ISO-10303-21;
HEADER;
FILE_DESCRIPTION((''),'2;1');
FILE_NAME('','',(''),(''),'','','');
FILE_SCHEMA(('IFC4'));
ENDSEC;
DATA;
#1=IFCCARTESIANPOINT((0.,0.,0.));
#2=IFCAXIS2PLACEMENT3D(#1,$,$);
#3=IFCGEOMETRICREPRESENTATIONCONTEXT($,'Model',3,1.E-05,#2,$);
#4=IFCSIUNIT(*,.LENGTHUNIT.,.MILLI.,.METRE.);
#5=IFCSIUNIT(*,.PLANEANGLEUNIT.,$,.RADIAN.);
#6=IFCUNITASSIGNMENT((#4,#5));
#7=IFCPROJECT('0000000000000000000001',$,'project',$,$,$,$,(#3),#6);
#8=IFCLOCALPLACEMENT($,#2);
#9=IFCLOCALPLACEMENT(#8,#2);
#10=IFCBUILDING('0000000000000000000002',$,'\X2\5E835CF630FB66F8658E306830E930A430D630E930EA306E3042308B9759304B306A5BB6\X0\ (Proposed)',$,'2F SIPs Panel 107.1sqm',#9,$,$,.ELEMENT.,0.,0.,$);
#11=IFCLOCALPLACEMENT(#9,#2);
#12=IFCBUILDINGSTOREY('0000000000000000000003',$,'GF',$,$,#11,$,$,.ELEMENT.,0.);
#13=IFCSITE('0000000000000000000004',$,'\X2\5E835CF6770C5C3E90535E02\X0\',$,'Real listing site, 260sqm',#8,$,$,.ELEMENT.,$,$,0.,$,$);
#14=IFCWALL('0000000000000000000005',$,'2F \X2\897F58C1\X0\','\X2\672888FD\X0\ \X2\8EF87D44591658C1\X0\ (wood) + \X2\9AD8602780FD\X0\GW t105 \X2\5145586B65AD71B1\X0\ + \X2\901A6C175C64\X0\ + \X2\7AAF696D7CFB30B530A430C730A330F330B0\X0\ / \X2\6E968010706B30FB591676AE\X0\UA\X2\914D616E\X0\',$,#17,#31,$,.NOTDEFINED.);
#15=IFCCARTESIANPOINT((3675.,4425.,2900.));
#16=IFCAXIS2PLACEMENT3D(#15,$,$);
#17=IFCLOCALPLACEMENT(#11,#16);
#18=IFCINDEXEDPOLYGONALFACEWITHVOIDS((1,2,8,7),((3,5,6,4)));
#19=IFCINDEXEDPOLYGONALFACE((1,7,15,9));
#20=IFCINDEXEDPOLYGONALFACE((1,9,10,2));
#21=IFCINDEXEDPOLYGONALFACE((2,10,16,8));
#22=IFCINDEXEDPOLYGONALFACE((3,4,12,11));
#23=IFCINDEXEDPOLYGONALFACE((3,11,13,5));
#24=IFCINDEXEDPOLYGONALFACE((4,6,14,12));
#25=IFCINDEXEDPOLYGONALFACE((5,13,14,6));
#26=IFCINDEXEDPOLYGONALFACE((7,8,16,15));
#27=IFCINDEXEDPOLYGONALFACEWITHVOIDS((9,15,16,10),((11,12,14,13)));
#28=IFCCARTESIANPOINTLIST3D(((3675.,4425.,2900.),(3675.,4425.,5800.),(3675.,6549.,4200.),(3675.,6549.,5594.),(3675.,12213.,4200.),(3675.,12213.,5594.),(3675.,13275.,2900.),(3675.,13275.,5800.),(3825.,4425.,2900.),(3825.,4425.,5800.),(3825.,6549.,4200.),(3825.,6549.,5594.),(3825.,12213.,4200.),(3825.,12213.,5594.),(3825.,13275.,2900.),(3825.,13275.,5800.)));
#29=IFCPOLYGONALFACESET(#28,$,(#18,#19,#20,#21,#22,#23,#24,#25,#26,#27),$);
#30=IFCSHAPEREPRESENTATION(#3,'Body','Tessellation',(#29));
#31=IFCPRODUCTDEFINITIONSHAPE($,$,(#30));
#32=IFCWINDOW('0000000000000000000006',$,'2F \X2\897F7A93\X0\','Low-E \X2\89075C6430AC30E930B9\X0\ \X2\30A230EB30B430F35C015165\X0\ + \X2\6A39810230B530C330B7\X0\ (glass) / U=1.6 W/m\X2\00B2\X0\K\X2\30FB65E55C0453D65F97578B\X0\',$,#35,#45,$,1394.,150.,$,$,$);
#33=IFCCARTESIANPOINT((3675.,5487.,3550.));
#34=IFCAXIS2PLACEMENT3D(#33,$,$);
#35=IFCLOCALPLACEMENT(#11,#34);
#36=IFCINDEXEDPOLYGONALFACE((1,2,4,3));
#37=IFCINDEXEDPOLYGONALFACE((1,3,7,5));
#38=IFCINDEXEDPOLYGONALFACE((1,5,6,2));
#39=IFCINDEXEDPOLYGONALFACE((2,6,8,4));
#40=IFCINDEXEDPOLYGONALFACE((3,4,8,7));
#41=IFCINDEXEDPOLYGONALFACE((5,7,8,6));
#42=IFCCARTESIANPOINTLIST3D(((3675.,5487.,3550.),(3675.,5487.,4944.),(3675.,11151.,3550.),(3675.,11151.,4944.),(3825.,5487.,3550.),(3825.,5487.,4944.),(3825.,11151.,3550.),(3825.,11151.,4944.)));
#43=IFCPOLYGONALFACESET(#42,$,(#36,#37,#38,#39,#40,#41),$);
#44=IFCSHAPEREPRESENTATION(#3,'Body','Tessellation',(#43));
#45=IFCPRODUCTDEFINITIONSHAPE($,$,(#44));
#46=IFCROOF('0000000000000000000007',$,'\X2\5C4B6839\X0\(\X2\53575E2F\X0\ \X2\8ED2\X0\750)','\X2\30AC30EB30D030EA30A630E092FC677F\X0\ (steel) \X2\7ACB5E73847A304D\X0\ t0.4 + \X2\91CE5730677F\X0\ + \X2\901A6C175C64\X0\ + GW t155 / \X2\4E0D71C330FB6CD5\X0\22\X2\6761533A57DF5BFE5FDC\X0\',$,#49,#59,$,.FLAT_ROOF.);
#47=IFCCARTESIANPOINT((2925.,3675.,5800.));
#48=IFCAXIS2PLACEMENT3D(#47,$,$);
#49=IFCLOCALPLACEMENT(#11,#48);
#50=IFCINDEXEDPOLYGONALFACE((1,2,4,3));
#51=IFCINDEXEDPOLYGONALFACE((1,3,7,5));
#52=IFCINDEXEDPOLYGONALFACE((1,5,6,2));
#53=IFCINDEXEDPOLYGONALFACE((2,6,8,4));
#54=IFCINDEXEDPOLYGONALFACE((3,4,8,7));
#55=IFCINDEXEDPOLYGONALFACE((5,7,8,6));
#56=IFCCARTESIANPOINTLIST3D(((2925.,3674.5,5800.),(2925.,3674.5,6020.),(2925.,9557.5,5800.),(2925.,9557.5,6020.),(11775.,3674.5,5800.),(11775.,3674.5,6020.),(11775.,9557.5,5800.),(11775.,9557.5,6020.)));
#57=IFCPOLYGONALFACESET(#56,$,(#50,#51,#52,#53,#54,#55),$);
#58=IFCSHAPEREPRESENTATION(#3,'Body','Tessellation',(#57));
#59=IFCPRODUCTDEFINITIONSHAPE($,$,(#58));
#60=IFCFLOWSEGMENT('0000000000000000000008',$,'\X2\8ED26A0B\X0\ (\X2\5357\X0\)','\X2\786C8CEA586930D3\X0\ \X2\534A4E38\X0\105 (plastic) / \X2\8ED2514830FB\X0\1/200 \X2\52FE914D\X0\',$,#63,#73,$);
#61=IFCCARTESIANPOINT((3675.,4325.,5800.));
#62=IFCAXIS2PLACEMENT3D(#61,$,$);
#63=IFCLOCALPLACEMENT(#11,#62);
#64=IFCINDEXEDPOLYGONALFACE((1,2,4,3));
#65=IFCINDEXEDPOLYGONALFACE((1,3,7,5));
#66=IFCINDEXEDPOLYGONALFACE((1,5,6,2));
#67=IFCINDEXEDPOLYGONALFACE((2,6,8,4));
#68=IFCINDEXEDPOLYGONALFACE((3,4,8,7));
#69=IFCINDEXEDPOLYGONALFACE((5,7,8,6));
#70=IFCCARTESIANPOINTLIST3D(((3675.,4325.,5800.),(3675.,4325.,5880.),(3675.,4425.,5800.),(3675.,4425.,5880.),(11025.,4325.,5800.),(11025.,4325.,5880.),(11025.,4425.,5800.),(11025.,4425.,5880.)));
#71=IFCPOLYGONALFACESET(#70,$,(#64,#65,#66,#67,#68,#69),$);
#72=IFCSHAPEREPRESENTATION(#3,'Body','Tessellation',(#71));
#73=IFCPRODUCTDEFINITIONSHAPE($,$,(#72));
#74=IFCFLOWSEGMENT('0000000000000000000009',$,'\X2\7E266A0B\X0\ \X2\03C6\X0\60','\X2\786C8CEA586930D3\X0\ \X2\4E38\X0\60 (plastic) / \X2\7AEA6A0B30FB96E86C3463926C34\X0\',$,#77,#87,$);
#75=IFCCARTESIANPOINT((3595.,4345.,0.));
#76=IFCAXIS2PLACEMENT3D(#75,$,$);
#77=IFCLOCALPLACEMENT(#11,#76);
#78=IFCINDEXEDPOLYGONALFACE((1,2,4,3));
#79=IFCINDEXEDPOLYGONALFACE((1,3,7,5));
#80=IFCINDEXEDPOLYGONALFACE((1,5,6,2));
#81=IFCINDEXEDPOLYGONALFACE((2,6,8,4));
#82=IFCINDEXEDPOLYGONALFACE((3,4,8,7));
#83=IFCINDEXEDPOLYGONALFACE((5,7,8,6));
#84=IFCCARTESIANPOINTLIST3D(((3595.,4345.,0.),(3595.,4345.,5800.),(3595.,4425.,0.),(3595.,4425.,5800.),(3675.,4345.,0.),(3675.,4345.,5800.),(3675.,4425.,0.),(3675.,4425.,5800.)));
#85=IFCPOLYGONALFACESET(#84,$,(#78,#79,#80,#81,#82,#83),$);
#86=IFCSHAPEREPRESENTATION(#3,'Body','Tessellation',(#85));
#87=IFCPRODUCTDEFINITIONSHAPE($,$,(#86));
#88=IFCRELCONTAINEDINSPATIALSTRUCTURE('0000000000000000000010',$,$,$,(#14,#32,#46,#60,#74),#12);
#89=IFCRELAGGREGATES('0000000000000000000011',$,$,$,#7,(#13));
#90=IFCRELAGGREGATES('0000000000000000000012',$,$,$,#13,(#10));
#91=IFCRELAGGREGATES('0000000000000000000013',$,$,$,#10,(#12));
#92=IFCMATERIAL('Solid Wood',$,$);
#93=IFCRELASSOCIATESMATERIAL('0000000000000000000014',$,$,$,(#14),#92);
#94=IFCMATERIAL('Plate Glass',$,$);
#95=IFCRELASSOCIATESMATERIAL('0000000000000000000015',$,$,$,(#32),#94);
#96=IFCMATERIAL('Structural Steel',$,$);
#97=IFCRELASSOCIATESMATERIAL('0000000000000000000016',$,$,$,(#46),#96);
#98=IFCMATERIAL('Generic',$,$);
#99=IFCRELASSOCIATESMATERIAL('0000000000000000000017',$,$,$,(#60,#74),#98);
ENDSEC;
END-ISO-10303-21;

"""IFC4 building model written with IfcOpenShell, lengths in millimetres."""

from ifc_helpers import new_model, si_unit, frame, frame_2d, origin, place, context, project, spatial, rectangle, extrude, material, element, fill, save


model = new_model("IFC4")

# Units and contexts
model_context = context("Model", 3, precision=1e-05, world=origin())
ifc_project = project(units=[si_unit("LENGTHUNIT", "METRE", prefix="MILLI"), si_unit("PLANEANGLEUNIT", "RADIAN")], contexts=[model_context])

# Site, building, storey
site_placement = place(None, origin())
site = spatial("IfcSite", under=ifc_project, at=site_placement, Name="広島県尾道市", ObjectType="Real listing site, 260sqm", CompositionType="ELEMENT", RefElevation=0.0)
building_placement = place(site_placement, origin())
building = spatial("IfcBuilding", under=site, at=building_placement, Name="広島・書斎とライブラリのある静かな家 (Proposed)", ObjectType="2F SIPs Panel 107.1sqm", CompositionType="ELEMENT", ElevationOfRefHeight=0.0, ElevationOfTerrain=0.0)
storey_placement = place(building_placement, origin())
storey = spatial("IfcBuildingStorey", under=building, at=storey_placement, Name="GF", CompositionType="ELEMENT", Elevation=0.0)

# Shared definitions
ifc_material_1 = material(Name="Solid Wood")

# Shared definitions
ifc_material_2 = material(Name="Plate Glass")

# Wall, opening, window
wall_1_placement = place(storey_placement, frame((3675.0, 4425.0, 2900.0)))
wall_1 = element("IfcWall", 1, at=wall_1_placement, inside=storey, material=ifc_material_1, Name="2F 西壁", Description="木製 軸組外壁 (wood) + 高性能GW t105 充填断熱 + 通気層 + 窯業系サイディング / 準耐火・外皮UA配慮", PredefinedType="NOTDEFINED", context=model_context, shape_type="SweptSolid", body=[
    extrude(rectangle(XDim=150.0, YDim=8850.0, at=frame_2d((75.0, 4425.0))), frame((3675.0, 4425.0, 2900.0)), (0.0, 0.0, 1.0), 2900.0),
])
opening_1_placement = place(storey_placement, frame((3675.0, 5487.0, 3550.0)))
opening_1 = element("IfcOpeningElement", 2, at=opening_1_placement, cuts=wall_1, PredefinedType="NOTDEFINED", context=model_context, shape_type="SweptSolid", body=[
    extrude(rectangle(XDim=150.0, YDim=5664.0, at=frame_2d((75.0, 2832.0))), frame((3675.0, 5487.0, 3550.0)), (0.0, 0.0, 1.0), 1394.0),
])
window_1_placement = place(storey_placement, frame((3675.0, 5487.0, 3550.0)))
window_1 = element("IfcWindow", 3, at=window_1_placement, inside=storey, material=ifc_material_2, Name="2F 西窓", Description="Low-E 複層ガラス アルゴン封入 + 樹脂サッシ (glass) / U=1.6 W/m²K・日射取得型", OverallHeight=1394.0, OverallWidth=150.0, context=model_context, shape_type="SweptSolid", body=[
    extrude(rectangle(XDim=150.0, YDim=5664.0, at=frame_2d((75.0, 2832.0))), frame((3675.0, 5487.0, 3550.0)), (0.0, 0.0, 1.0), 1394.0),
])
fill(opening_1, window_1)

# Roof
ifc_material_3 = material(Name="Structural Steel")
for number, where, name in (
    (4, (2925.0, 3675.0, 5800.0), "屋根(南帯 軒750)"),
):
    element("IfcRoof", number, at=place(storey_placement, frame(where)), inside=storey, material=ifc_material_3, Name=name, Description="ガルバリウム鋼板 (steel) 立平葺き t0.4 + 野地板 + 通気層 + GW t155 / 不燃・法22条区域対応", PredefinedType="FLAT_ROOF", context=model_context, shape_type="SweptSolid", body=[
        extrude(rectangle(XDim=8850.0, YDim=5883.0, at=frame_2d((4425.0, 2941.0))), frame((2925.0, 3675.0, 5800.0)), (0.0, 0.0, 1.0), 220.0),
    ])

# Flow segments
ifc_material_4 = material(Name="Generic")
flow_segment_1_placement = place(storey_placement, frame((3675.0, 4325.0, 5800.0)))
element("IfcFlowSegment", 5, at=flow_segment_1_placement, inside=storey, material=ifc_material_4, Name="軒樋 (南)", Description="硬質塩ビ 半丸105 (plastic) / 軒先・1/200 勾配", context=model_context, shape_type="SweptSolid", body=[
    extrude(rectangle(XDim=7350.0, YDim=100.0, at=frame_2d((3675.0, 50.0))), frame((3675.0, 4325.0, 5800.0)), (0.0, 0.0, 1.0), 80.0),
])
flow_segment_2_placement = place(storey_placement, frame((3595.0, 4345.0, 0.0)))
element("IfcFlowSegment", 6, at=flow_segment_2_placement, inside=storey, material=ifc_material_4, Name="縦樋 φ60", Description="硬質塩ビ 丸60 (plastic) / 竪樋・雨水排水", context=model_context, shape_type="SweptSolid", body=[
    extrude(rectangle(XDim=80.0, YDim=80.0, at=frame_2d((40.0, 40.0))), frame((3595.0, 4345.0, 0.0)), (0.0, 0.0, 1.0), 5800.0),
])

save(model, "model.ifc")
